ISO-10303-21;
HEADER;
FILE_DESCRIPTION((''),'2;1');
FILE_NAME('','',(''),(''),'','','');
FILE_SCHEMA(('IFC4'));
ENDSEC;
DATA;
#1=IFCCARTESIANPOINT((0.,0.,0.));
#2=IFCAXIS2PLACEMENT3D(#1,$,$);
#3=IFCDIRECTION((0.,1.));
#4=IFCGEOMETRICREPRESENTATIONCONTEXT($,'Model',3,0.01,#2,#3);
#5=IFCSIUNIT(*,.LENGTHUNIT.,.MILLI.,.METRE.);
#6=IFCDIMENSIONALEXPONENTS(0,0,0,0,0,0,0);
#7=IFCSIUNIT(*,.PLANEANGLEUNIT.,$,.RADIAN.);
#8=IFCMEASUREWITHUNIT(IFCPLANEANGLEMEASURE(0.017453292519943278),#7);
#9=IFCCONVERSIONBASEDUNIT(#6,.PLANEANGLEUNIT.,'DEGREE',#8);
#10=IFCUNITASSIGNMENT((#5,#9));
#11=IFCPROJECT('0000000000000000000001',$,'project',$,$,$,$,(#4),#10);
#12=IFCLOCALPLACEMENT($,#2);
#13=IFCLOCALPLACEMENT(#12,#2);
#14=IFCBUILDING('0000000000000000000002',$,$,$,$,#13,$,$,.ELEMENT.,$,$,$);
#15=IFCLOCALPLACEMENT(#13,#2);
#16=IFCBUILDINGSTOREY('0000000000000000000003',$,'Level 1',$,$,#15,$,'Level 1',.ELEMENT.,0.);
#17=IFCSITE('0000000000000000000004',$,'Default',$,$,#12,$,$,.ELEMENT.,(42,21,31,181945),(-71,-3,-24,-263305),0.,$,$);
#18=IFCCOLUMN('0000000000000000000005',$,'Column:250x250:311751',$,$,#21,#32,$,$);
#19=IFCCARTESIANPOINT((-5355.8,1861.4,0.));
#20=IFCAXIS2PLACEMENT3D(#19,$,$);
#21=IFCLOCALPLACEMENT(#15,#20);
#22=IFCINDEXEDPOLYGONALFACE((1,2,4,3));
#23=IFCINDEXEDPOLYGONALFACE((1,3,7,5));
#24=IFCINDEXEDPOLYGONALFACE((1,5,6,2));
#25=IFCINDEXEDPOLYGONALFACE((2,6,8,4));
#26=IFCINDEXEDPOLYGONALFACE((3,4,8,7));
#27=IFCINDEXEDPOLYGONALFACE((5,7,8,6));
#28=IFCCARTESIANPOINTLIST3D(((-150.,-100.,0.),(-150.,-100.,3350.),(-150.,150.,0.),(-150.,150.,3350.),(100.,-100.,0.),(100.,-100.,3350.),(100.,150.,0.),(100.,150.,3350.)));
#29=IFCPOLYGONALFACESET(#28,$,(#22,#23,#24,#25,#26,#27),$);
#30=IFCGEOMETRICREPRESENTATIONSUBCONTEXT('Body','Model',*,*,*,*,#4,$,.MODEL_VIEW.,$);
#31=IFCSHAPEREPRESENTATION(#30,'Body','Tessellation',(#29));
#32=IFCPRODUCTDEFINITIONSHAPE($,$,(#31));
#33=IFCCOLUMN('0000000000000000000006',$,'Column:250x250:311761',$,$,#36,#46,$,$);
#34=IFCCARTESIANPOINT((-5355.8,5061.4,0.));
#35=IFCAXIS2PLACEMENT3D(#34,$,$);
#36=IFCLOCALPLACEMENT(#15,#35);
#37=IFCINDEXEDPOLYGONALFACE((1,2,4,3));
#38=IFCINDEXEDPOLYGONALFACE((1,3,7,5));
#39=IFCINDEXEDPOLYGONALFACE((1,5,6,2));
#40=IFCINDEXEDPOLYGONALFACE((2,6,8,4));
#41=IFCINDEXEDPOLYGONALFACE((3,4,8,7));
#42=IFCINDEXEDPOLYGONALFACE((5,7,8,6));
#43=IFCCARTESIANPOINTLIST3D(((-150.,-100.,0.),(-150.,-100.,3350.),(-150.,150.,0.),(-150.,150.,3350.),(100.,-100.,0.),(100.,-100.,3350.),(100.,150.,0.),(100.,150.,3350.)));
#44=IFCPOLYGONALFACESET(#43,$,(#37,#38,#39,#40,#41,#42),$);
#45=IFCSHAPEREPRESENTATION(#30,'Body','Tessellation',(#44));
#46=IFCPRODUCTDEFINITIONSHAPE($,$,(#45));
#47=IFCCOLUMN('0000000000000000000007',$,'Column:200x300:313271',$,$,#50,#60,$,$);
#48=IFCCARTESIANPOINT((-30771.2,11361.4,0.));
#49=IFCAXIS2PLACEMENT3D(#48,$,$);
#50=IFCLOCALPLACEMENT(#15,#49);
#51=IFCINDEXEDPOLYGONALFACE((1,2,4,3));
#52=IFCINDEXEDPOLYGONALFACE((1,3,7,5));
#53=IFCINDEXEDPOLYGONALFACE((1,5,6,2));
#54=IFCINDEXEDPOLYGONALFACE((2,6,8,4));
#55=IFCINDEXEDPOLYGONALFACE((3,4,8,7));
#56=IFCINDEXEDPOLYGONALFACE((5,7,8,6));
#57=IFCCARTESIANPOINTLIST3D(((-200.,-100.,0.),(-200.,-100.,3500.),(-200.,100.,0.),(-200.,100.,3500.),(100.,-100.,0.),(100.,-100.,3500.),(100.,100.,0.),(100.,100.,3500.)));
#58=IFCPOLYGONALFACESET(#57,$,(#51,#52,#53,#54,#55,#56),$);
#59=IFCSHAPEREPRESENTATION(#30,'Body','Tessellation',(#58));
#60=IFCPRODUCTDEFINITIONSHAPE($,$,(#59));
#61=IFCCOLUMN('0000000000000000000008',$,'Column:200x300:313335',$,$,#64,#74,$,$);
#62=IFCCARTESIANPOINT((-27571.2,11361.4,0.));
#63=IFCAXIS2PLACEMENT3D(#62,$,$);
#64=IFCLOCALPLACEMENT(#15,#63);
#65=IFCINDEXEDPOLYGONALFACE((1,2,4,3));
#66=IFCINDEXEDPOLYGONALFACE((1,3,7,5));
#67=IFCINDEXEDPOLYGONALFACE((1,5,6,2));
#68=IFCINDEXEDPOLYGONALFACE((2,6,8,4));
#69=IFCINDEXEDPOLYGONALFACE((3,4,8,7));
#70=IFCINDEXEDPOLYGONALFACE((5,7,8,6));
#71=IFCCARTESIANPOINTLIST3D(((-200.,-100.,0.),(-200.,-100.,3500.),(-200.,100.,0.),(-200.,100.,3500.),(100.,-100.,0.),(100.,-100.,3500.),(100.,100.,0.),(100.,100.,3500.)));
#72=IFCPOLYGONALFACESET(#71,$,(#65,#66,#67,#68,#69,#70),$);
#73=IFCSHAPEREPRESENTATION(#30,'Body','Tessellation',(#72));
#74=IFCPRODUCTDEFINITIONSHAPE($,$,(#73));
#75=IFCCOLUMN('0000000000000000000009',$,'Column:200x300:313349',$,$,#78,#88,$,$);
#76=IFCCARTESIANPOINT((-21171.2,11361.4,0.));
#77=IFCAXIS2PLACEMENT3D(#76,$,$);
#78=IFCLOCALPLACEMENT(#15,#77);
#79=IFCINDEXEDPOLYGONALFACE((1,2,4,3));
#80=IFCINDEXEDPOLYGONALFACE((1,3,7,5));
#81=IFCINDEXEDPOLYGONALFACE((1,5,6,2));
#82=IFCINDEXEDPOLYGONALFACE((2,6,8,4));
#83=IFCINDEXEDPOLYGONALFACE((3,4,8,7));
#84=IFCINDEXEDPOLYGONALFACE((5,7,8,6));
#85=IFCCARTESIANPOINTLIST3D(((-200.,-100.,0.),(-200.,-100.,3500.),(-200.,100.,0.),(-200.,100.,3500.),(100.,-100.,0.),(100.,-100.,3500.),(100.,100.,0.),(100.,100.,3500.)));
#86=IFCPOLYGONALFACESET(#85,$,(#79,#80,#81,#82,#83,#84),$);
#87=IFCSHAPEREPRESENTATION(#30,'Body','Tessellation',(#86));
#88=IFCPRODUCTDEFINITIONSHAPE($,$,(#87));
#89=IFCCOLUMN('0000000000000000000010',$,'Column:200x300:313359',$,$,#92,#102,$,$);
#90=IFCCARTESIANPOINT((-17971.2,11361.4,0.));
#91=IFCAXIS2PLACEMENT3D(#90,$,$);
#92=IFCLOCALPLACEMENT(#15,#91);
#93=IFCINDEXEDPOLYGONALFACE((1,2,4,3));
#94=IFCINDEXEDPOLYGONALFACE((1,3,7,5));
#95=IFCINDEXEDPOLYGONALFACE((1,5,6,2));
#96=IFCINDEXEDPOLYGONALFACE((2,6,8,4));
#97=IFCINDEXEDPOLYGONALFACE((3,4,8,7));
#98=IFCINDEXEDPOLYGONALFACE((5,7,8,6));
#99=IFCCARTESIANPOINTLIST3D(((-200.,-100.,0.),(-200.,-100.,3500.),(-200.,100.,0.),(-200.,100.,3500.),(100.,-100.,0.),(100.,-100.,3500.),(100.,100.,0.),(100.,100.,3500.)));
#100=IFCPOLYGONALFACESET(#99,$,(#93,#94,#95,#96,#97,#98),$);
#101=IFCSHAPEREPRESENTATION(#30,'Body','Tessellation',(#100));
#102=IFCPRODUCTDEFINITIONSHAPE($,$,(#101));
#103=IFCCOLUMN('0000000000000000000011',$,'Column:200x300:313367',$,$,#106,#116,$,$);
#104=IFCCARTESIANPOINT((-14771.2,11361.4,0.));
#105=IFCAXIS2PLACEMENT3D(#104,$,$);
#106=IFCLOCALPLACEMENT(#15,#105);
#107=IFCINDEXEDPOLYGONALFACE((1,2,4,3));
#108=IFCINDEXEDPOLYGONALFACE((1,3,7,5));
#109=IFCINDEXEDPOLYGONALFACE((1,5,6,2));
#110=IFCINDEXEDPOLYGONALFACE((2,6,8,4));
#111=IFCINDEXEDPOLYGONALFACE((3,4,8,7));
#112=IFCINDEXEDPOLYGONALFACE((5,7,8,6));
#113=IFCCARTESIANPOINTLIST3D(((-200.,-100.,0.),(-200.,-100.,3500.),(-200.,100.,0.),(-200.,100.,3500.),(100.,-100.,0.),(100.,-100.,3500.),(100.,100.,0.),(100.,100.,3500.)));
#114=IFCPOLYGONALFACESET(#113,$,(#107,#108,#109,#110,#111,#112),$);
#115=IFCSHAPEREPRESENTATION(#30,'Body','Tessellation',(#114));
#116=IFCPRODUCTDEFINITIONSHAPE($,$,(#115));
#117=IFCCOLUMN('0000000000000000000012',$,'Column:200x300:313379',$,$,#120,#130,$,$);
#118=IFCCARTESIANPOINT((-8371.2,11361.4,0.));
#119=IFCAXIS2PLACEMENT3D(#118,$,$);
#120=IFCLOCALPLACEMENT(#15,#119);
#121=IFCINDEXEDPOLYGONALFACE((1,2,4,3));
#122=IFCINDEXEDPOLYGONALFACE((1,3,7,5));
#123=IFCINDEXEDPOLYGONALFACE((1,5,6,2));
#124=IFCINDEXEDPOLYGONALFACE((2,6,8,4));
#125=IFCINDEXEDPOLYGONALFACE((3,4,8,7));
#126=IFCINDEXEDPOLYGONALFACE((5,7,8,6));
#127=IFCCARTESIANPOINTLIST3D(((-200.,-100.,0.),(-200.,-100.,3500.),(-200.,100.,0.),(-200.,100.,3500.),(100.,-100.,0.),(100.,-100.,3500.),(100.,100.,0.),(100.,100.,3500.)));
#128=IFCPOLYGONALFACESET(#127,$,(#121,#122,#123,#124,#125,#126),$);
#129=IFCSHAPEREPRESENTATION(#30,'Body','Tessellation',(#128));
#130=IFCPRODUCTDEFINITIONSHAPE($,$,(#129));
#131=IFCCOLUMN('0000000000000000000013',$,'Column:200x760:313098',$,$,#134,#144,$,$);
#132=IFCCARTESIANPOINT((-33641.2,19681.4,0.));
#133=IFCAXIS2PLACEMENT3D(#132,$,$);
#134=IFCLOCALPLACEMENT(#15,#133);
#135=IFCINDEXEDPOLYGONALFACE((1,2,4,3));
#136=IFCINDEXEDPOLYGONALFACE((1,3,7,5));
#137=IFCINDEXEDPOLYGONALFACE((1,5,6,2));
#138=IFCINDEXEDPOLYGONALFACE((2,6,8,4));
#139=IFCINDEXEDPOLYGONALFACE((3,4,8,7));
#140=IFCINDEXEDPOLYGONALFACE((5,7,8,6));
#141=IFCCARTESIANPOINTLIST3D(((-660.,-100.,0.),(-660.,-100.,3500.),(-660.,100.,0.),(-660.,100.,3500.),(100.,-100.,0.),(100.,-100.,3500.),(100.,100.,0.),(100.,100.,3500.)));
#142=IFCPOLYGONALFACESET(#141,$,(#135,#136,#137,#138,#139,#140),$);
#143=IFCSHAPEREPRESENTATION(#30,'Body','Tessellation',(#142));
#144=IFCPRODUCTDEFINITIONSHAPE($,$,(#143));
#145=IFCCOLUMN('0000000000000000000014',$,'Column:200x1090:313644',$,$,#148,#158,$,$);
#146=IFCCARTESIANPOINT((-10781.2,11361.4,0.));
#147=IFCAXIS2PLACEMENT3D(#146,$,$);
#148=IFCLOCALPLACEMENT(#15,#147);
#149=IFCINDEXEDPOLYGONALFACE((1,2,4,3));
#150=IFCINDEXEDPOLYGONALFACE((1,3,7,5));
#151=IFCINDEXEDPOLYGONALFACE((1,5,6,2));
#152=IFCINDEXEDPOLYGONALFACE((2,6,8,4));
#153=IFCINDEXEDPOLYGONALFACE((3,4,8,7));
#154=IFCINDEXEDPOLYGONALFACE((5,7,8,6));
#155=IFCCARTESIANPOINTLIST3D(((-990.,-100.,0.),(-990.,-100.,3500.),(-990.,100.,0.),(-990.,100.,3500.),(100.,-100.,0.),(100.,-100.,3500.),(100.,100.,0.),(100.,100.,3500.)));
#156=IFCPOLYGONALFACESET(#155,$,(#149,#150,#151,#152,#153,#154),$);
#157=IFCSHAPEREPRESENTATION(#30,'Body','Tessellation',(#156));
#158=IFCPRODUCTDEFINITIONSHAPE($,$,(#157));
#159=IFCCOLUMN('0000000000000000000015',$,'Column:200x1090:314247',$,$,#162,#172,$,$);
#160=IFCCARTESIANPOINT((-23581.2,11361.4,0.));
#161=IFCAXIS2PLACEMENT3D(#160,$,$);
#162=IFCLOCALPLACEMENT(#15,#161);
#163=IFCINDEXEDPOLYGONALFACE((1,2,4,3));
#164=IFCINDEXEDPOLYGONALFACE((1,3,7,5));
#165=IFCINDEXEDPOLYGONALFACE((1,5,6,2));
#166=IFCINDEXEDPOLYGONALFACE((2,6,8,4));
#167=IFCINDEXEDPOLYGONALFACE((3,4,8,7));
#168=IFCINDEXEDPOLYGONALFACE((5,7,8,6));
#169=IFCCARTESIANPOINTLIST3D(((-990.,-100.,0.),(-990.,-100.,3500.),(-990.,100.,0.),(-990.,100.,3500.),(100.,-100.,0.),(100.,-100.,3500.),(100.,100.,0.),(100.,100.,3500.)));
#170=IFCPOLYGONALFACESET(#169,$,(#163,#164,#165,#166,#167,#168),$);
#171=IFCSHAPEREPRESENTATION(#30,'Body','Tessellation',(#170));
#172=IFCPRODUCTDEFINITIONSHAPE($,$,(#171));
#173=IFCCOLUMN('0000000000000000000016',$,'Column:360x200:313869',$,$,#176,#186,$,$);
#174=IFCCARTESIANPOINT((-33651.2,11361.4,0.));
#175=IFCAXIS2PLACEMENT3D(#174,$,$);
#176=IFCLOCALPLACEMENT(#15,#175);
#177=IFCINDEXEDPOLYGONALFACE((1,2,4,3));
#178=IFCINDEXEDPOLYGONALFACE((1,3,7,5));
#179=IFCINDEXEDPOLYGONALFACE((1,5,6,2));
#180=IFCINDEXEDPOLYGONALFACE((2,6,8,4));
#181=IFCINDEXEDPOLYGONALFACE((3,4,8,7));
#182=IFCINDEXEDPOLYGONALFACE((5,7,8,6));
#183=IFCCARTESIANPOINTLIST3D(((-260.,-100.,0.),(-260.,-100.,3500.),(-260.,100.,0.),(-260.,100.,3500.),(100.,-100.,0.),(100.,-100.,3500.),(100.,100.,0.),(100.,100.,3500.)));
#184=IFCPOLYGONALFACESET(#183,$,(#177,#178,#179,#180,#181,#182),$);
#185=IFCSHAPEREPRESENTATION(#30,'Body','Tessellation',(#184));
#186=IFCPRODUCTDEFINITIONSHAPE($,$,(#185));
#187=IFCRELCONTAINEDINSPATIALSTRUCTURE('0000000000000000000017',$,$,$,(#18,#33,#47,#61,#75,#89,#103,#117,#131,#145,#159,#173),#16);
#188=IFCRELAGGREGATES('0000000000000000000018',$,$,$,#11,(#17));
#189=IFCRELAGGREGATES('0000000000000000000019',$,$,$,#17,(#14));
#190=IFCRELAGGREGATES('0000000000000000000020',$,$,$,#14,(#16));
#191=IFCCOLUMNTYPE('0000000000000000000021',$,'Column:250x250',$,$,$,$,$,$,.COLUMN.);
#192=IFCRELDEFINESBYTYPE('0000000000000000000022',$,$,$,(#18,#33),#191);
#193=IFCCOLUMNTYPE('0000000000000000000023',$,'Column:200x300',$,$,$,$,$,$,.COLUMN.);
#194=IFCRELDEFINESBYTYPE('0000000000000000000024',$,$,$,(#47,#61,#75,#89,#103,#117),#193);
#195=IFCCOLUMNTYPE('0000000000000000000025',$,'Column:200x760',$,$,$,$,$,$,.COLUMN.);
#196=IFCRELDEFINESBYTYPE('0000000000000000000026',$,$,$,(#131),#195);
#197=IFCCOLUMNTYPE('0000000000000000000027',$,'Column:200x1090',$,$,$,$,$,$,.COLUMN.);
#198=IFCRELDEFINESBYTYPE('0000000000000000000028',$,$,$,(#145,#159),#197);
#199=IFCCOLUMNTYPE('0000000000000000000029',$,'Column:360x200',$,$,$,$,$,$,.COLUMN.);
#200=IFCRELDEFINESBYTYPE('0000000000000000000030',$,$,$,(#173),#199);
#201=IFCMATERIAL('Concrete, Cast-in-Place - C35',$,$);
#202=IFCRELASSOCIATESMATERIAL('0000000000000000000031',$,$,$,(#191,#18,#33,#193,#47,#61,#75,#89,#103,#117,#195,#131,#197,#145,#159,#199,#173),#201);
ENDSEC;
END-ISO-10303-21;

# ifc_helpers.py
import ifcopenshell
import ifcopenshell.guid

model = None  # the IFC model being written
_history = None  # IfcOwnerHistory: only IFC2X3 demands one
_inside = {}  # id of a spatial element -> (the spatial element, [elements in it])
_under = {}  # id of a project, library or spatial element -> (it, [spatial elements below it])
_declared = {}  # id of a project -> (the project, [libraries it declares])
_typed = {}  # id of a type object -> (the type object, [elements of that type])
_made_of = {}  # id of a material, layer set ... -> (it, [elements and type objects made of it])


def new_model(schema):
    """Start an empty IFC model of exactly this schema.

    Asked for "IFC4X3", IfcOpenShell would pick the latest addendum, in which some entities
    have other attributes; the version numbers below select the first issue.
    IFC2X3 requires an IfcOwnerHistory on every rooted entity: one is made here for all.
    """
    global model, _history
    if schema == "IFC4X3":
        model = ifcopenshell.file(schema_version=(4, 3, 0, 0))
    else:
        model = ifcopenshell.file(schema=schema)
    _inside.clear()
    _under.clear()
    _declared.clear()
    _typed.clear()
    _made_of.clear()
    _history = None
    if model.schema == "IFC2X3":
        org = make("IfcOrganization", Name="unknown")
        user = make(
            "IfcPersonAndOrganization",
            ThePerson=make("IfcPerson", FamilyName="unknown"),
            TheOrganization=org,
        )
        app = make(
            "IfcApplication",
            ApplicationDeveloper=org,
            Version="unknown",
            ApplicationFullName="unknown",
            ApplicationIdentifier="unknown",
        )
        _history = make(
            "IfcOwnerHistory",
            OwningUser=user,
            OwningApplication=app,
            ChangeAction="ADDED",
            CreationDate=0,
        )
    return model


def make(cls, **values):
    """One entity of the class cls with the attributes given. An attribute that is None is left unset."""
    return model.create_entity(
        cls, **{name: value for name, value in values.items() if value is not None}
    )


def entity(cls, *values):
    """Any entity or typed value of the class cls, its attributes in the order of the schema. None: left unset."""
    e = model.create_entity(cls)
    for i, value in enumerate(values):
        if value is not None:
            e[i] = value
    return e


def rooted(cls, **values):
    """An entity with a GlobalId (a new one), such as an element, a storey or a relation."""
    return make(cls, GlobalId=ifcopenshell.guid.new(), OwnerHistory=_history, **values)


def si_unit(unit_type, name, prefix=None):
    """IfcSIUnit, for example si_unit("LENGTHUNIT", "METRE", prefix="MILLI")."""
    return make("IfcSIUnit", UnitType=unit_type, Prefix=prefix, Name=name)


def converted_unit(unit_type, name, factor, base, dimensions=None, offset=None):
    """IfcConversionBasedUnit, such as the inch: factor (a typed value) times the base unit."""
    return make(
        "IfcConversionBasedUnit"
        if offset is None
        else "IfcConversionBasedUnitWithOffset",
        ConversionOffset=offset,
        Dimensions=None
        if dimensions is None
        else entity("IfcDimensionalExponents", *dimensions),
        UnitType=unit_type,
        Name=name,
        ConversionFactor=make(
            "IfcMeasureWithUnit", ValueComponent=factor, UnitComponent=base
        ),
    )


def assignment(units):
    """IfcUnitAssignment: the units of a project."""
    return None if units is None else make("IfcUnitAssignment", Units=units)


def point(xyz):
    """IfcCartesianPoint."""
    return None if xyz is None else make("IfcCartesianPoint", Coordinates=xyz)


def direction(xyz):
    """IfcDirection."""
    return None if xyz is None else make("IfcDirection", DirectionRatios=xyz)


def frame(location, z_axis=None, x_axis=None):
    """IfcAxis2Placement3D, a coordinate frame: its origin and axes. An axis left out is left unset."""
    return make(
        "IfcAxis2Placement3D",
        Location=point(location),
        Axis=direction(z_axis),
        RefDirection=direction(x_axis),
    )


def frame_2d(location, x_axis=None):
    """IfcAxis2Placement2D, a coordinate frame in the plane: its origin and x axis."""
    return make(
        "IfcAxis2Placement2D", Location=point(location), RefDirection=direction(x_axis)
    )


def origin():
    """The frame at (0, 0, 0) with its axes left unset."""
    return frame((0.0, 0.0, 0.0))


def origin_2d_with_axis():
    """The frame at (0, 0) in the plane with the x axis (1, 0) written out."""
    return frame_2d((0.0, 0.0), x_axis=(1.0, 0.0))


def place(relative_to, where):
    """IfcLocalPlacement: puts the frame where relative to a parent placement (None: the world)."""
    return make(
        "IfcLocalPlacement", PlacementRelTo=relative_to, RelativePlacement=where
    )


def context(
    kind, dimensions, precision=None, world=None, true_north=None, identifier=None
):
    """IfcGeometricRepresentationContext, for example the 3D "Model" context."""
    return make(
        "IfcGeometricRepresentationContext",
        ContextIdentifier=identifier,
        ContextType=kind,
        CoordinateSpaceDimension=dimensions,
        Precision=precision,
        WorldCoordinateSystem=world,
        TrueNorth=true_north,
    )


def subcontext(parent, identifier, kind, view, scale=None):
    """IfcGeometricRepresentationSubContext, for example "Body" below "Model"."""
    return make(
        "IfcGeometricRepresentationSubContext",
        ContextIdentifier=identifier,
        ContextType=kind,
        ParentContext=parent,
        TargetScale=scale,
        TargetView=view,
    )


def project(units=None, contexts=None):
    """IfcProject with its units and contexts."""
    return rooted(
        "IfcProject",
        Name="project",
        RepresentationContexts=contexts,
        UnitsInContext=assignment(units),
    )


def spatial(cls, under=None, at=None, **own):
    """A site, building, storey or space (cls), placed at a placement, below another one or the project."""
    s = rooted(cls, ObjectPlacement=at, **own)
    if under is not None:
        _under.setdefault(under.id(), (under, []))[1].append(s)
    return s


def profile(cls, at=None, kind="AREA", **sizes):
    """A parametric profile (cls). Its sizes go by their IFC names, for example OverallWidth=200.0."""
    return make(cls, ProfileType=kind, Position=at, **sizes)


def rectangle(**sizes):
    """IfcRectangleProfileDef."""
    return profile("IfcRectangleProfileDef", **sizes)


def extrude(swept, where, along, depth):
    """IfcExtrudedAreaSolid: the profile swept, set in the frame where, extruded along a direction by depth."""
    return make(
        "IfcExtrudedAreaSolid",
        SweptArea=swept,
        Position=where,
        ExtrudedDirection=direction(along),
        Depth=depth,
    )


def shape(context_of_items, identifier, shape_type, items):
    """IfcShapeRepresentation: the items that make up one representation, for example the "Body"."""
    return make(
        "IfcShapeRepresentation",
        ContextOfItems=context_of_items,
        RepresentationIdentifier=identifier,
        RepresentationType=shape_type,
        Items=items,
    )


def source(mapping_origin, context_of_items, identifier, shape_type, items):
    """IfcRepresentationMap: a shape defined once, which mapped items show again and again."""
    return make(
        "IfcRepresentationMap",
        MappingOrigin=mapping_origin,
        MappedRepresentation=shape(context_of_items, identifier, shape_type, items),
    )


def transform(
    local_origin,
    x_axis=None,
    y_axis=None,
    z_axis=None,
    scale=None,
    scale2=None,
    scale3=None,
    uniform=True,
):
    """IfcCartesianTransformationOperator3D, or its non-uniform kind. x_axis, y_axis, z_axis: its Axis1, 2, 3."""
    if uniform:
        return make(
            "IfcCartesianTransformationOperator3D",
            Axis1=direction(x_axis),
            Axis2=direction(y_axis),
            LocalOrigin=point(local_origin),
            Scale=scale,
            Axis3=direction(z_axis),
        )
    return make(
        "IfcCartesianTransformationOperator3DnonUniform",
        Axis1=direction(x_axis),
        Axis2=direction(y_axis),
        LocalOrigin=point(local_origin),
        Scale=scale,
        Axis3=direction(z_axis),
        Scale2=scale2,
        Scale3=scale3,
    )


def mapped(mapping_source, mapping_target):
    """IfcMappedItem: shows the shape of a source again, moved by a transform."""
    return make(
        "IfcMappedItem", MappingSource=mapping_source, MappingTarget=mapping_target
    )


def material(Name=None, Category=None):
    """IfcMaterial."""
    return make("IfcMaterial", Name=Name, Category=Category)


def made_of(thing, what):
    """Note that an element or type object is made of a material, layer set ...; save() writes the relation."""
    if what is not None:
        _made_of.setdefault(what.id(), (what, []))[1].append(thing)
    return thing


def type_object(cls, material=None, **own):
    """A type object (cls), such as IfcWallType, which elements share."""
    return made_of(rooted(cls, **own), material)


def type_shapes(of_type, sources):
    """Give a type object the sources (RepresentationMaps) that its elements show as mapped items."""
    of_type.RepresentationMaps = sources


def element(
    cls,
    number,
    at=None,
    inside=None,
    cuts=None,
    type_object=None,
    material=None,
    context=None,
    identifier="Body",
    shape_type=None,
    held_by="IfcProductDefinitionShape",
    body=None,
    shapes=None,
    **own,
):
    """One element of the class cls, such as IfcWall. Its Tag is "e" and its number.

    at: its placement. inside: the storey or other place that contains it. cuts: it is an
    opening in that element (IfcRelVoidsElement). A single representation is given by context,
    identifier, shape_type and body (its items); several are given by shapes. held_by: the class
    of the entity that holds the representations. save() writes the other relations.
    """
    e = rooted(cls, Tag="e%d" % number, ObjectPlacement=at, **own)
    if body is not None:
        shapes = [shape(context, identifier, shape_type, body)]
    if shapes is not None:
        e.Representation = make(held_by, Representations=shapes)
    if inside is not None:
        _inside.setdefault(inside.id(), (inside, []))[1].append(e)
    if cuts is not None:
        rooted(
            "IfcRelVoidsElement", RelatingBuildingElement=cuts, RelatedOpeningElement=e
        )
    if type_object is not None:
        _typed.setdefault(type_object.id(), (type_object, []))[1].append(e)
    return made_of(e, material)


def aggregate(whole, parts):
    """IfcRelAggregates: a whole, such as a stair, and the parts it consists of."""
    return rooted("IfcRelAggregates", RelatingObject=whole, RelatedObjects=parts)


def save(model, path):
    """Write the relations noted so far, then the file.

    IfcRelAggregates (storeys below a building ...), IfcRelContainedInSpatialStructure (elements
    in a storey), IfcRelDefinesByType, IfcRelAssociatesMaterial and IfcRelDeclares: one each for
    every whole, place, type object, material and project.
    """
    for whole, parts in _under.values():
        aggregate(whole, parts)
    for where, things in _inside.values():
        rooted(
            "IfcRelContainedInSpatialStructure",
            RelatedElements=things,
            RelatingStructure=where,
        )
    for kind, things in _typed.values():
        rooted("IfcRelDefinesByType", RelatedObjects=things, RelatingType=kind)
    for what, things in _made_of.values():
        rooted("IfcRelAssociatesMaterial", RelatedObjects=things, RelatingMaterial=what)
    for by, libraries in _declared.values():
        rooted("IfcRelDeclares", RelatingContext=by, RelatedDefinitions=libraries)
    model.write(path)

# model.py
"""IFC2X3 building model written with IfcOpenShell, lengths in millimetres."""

from ifc_helpers import new_model, entity, si_unit, converted_unit, direction, frame, frame_2d, origin, origin_2d_with_axis, place, context, subcontext, project, spatial, rectangle, extrude, source, transform, mapped, material, type_object, type_shapes, element, save


model = new_model("IFC2X3")

# Units and contexts
model_context = context("Model", 3, precision=0.01, world=origin(), true_north=direction((0.0, 1.0)))
body_context = subcontext(model_context, "Body", "Model", "MODEL_VIEW")
ifc_project = project(units=[si_unit("LENGTHUNIT", "METRE", prefix="MILLI"), converted_unit("PLANEANGLEUNIT", "DEGREE", entity("IfcPlaneAngleMeasure", 0.017453292519943278), si_unit("PLANEANGLEUNIT", "RADIAN"), dimensions=[0, 0, 0, 0, 0, 0, 0])], contexts=[model_context])

# Site, building, storey
site_placement = place(None, origin())
site = spatial("IfcSite", under=ifc_project, at=site_placement, Name="Default", CompositionType="ELEMENT", RefLatitude=(42, 21, 31, 181945), RefLongitude=(-71, -3, -24, -263305), RefElevation=0.0)
building_placement = place(site_placement, origin())
building = spatial("IfcBuilding", under=site, at=building_placement, CompositionType="ELEMENT")
storey_placement = place(building_placement, origin())
storey = spatial("IfcBuildingStorey", under=building, at=storey_placement, Name="Level 1", LongName="Level 1", CompositionType="ELEMENT", Elevation=0.0)

# Columns
ifc_material = material(Name="Concrete, Cast-in-Place - C35")
column_type_1 = type_object("IfcColumnType", Name="Column:250x250", PredefinedType="COLUMN", material=ifc_material)
shared_shape_1 = source(origin(), body_context, "Body", "SweptSolid", [
    extrude(rectangle(XDim=250.0, YDim=250.0, at=origin_2d_with_axis()), frame((-25.0, 25.0, 0.0), z_axis=(0.0, 0.0, 1.0), x_axis=(-1.0, 0.0, 0.0)), (0.0, 0.0, 1.0), 3350.0),
])
type_shapes(column_type_1, [shared_shape_1])
for number, where, name in (
    (1, (-5355.8, 1861.4, 0.0), "Column:250x250:311751"),
    (2, (-5355.8, 5061.4, 0.0), "Column:250x250:311761"),
):
    element("IfcColumn", number, at=place(storey_placement, frame(where)), inside=storey, type_object=column_type_1, material=ifc_material, Name=name, context=body_context, shape_type="MappedRepresentation", body=[
        mapped(shared_shape_1, transform((0.0, 0.0, 0.0), scale=1.0)),
    ])
column_type_2 = type_object("IfcColumnType", Name="Column:200x300", PredefinedType="COLUMN", material=ifc_material)
shared_shape_2 = source(origin(), body_context, "Body", "SweptSolid", [
    extrude(rectangle(XDim=300.0, YDim=200.0, at=origin_2d_with_axis()), frame((-50.0, 0.0, 0.0), z_axis=(0.0, 0.0, 1.0), x_axis=(-1.0, 0.0, 0.0)), (0.0, 0.0, 1.0), 3500.0),
])
type_shapes(column_type_2, [shared_shape_2])
for number, where, name in (
    (3, (-30771.2, 11361.4, 0.0), "Column:200x300:313271"),
    (4, (-27571.2, 11361.4, 0.0), "Column:200x300:313335"),
    (5, (-21171.2, 11361.4, 0.0), "Column:200x300:313349"),
    (6, (-17971.2, 11361.4, 0.0), "Column:200x300:313359"),
    (7, (-14771.2, 11361.4, 0.0), "Column:200x300:313367"),
    (8, (-8371.2, 11361.4, 0.0), "Column:200x300:313379"),
):
    element("IfcColumn", number, at=place(storey_placement, frame(where)), inside=storey, type_object=column_type_2, material=ifc_material, Name=name, context=body_context, shape_type="MappedRepresentation", body=[
        mapped(shared_shape_2, transform((0.0, 0.0, 0.0), scale=1.0)),
    ])
column_type_3 = type_object("IfcColumnType", Name="Column:200x760", PredefinedType="COLUMN", material=ifc_material)
shared_shape_3 = source(origin(), body_context, "Body", "SweptSolid", [
    extrude(rectangle(XDim=760.0, YDim=200.0, at=frame_2d((0.0, 0.0), x_axis=(1.0, 0.0))), frame((-280.0, 0.0, 0.0), z_axis=(0.0, 0.0, 1.0), x_axis=(-1.0, 0.0, 0.0)), (0.0, 0.0, 1.0), 3500.0),
])
type_shapes(column_type_3, [shared_shape_3])
column_1_placement = place(storey_placement, frame((-33641.2, 19681.4, 0.0)))
element("IfcColumn", 9, at=column_1_placement, inside=storey, type_object=column_type_3, material=ifc_material, Name="Column:200x760:313098", context=body_context, shape_type="MappedRepresentation", body=[
    mapped(shared_shape_3, transform((0.0, 0.0, 0.0), scale=1.0)),
])
column_type_4 = type_object("IfcColumnType", Name="Column:200x1090", PredefinedType="COLUMN", material=ifc_material)
shared_shape_4 = source(origin(), body_context, "Body", "SweptSolid", [
    extrude(rectangle(XDim=1090.0, YDim=200.0, at=frame_2d((0.0, 0.0), x_axis=(1.0, 0.0))), frame((-445.0, 0.0, 0.0), z_axis=(0.0, 0.0, 1.0), x_axis=(-1.0, 0.0, 0.0)), (0.0, 0.0, 1.0), 3500.0),
])
type_shapes(column_type_4, [shared_shape_4])
for number, where, name in (
    (10, (-10781.2, 11361.4, 0.0), "Column:200x1090:313644"),
    (11, (-23581.2, 11361.4, 0.0), "Column:200x1090:314247"),
):
    element("IfcColumn", number, at=place(storey_placement, frame(where)), inside=storey, type_object=column_type_4, material=ifc_material, Name=name, context=body_context, shape_type="MappedRepresentation", body=[
        mapped(shared_shape_4, transform((0.0, 0.0, 0.0), scale=1.0)),
    ])
column_type_5 = type_object("IfcColumnType", Name="Column:360x200", PredefinedType="COLUMN", material=ifc_material)
shared_shape_5 = source(origin(), body_context, "Body", "SweptSolid", [
    extrude(rectangle(XDim=360.0, YDim=200.0, at=origin_2d_with_axis()), frame((-80.0, 0.0, 0.0), z_axis=(0.0, 0.0, 1.0), x_axis=(-1.0, 0.0, 0.0)), (0.0, 0.0, 1.0), 3500.0),
])
type_shapes(column_type_5, [shared_shape_5])
column_2_placement = place(storey_placement, frame((-33651.2, 11361.4, 0.0)))
element("IfcColumn", 12, at=column_2_placement, inside=storey, type_object=column_type_5, material=ifc_material, Name="Column:360x200:313869", context=body_context, shape_type="MappedRepresentation", body=[
    mapped(shared_shape_5, transform((0.0, 0.0, 0.0), scale=1.0)),
])

save(model, "model.ifc")
